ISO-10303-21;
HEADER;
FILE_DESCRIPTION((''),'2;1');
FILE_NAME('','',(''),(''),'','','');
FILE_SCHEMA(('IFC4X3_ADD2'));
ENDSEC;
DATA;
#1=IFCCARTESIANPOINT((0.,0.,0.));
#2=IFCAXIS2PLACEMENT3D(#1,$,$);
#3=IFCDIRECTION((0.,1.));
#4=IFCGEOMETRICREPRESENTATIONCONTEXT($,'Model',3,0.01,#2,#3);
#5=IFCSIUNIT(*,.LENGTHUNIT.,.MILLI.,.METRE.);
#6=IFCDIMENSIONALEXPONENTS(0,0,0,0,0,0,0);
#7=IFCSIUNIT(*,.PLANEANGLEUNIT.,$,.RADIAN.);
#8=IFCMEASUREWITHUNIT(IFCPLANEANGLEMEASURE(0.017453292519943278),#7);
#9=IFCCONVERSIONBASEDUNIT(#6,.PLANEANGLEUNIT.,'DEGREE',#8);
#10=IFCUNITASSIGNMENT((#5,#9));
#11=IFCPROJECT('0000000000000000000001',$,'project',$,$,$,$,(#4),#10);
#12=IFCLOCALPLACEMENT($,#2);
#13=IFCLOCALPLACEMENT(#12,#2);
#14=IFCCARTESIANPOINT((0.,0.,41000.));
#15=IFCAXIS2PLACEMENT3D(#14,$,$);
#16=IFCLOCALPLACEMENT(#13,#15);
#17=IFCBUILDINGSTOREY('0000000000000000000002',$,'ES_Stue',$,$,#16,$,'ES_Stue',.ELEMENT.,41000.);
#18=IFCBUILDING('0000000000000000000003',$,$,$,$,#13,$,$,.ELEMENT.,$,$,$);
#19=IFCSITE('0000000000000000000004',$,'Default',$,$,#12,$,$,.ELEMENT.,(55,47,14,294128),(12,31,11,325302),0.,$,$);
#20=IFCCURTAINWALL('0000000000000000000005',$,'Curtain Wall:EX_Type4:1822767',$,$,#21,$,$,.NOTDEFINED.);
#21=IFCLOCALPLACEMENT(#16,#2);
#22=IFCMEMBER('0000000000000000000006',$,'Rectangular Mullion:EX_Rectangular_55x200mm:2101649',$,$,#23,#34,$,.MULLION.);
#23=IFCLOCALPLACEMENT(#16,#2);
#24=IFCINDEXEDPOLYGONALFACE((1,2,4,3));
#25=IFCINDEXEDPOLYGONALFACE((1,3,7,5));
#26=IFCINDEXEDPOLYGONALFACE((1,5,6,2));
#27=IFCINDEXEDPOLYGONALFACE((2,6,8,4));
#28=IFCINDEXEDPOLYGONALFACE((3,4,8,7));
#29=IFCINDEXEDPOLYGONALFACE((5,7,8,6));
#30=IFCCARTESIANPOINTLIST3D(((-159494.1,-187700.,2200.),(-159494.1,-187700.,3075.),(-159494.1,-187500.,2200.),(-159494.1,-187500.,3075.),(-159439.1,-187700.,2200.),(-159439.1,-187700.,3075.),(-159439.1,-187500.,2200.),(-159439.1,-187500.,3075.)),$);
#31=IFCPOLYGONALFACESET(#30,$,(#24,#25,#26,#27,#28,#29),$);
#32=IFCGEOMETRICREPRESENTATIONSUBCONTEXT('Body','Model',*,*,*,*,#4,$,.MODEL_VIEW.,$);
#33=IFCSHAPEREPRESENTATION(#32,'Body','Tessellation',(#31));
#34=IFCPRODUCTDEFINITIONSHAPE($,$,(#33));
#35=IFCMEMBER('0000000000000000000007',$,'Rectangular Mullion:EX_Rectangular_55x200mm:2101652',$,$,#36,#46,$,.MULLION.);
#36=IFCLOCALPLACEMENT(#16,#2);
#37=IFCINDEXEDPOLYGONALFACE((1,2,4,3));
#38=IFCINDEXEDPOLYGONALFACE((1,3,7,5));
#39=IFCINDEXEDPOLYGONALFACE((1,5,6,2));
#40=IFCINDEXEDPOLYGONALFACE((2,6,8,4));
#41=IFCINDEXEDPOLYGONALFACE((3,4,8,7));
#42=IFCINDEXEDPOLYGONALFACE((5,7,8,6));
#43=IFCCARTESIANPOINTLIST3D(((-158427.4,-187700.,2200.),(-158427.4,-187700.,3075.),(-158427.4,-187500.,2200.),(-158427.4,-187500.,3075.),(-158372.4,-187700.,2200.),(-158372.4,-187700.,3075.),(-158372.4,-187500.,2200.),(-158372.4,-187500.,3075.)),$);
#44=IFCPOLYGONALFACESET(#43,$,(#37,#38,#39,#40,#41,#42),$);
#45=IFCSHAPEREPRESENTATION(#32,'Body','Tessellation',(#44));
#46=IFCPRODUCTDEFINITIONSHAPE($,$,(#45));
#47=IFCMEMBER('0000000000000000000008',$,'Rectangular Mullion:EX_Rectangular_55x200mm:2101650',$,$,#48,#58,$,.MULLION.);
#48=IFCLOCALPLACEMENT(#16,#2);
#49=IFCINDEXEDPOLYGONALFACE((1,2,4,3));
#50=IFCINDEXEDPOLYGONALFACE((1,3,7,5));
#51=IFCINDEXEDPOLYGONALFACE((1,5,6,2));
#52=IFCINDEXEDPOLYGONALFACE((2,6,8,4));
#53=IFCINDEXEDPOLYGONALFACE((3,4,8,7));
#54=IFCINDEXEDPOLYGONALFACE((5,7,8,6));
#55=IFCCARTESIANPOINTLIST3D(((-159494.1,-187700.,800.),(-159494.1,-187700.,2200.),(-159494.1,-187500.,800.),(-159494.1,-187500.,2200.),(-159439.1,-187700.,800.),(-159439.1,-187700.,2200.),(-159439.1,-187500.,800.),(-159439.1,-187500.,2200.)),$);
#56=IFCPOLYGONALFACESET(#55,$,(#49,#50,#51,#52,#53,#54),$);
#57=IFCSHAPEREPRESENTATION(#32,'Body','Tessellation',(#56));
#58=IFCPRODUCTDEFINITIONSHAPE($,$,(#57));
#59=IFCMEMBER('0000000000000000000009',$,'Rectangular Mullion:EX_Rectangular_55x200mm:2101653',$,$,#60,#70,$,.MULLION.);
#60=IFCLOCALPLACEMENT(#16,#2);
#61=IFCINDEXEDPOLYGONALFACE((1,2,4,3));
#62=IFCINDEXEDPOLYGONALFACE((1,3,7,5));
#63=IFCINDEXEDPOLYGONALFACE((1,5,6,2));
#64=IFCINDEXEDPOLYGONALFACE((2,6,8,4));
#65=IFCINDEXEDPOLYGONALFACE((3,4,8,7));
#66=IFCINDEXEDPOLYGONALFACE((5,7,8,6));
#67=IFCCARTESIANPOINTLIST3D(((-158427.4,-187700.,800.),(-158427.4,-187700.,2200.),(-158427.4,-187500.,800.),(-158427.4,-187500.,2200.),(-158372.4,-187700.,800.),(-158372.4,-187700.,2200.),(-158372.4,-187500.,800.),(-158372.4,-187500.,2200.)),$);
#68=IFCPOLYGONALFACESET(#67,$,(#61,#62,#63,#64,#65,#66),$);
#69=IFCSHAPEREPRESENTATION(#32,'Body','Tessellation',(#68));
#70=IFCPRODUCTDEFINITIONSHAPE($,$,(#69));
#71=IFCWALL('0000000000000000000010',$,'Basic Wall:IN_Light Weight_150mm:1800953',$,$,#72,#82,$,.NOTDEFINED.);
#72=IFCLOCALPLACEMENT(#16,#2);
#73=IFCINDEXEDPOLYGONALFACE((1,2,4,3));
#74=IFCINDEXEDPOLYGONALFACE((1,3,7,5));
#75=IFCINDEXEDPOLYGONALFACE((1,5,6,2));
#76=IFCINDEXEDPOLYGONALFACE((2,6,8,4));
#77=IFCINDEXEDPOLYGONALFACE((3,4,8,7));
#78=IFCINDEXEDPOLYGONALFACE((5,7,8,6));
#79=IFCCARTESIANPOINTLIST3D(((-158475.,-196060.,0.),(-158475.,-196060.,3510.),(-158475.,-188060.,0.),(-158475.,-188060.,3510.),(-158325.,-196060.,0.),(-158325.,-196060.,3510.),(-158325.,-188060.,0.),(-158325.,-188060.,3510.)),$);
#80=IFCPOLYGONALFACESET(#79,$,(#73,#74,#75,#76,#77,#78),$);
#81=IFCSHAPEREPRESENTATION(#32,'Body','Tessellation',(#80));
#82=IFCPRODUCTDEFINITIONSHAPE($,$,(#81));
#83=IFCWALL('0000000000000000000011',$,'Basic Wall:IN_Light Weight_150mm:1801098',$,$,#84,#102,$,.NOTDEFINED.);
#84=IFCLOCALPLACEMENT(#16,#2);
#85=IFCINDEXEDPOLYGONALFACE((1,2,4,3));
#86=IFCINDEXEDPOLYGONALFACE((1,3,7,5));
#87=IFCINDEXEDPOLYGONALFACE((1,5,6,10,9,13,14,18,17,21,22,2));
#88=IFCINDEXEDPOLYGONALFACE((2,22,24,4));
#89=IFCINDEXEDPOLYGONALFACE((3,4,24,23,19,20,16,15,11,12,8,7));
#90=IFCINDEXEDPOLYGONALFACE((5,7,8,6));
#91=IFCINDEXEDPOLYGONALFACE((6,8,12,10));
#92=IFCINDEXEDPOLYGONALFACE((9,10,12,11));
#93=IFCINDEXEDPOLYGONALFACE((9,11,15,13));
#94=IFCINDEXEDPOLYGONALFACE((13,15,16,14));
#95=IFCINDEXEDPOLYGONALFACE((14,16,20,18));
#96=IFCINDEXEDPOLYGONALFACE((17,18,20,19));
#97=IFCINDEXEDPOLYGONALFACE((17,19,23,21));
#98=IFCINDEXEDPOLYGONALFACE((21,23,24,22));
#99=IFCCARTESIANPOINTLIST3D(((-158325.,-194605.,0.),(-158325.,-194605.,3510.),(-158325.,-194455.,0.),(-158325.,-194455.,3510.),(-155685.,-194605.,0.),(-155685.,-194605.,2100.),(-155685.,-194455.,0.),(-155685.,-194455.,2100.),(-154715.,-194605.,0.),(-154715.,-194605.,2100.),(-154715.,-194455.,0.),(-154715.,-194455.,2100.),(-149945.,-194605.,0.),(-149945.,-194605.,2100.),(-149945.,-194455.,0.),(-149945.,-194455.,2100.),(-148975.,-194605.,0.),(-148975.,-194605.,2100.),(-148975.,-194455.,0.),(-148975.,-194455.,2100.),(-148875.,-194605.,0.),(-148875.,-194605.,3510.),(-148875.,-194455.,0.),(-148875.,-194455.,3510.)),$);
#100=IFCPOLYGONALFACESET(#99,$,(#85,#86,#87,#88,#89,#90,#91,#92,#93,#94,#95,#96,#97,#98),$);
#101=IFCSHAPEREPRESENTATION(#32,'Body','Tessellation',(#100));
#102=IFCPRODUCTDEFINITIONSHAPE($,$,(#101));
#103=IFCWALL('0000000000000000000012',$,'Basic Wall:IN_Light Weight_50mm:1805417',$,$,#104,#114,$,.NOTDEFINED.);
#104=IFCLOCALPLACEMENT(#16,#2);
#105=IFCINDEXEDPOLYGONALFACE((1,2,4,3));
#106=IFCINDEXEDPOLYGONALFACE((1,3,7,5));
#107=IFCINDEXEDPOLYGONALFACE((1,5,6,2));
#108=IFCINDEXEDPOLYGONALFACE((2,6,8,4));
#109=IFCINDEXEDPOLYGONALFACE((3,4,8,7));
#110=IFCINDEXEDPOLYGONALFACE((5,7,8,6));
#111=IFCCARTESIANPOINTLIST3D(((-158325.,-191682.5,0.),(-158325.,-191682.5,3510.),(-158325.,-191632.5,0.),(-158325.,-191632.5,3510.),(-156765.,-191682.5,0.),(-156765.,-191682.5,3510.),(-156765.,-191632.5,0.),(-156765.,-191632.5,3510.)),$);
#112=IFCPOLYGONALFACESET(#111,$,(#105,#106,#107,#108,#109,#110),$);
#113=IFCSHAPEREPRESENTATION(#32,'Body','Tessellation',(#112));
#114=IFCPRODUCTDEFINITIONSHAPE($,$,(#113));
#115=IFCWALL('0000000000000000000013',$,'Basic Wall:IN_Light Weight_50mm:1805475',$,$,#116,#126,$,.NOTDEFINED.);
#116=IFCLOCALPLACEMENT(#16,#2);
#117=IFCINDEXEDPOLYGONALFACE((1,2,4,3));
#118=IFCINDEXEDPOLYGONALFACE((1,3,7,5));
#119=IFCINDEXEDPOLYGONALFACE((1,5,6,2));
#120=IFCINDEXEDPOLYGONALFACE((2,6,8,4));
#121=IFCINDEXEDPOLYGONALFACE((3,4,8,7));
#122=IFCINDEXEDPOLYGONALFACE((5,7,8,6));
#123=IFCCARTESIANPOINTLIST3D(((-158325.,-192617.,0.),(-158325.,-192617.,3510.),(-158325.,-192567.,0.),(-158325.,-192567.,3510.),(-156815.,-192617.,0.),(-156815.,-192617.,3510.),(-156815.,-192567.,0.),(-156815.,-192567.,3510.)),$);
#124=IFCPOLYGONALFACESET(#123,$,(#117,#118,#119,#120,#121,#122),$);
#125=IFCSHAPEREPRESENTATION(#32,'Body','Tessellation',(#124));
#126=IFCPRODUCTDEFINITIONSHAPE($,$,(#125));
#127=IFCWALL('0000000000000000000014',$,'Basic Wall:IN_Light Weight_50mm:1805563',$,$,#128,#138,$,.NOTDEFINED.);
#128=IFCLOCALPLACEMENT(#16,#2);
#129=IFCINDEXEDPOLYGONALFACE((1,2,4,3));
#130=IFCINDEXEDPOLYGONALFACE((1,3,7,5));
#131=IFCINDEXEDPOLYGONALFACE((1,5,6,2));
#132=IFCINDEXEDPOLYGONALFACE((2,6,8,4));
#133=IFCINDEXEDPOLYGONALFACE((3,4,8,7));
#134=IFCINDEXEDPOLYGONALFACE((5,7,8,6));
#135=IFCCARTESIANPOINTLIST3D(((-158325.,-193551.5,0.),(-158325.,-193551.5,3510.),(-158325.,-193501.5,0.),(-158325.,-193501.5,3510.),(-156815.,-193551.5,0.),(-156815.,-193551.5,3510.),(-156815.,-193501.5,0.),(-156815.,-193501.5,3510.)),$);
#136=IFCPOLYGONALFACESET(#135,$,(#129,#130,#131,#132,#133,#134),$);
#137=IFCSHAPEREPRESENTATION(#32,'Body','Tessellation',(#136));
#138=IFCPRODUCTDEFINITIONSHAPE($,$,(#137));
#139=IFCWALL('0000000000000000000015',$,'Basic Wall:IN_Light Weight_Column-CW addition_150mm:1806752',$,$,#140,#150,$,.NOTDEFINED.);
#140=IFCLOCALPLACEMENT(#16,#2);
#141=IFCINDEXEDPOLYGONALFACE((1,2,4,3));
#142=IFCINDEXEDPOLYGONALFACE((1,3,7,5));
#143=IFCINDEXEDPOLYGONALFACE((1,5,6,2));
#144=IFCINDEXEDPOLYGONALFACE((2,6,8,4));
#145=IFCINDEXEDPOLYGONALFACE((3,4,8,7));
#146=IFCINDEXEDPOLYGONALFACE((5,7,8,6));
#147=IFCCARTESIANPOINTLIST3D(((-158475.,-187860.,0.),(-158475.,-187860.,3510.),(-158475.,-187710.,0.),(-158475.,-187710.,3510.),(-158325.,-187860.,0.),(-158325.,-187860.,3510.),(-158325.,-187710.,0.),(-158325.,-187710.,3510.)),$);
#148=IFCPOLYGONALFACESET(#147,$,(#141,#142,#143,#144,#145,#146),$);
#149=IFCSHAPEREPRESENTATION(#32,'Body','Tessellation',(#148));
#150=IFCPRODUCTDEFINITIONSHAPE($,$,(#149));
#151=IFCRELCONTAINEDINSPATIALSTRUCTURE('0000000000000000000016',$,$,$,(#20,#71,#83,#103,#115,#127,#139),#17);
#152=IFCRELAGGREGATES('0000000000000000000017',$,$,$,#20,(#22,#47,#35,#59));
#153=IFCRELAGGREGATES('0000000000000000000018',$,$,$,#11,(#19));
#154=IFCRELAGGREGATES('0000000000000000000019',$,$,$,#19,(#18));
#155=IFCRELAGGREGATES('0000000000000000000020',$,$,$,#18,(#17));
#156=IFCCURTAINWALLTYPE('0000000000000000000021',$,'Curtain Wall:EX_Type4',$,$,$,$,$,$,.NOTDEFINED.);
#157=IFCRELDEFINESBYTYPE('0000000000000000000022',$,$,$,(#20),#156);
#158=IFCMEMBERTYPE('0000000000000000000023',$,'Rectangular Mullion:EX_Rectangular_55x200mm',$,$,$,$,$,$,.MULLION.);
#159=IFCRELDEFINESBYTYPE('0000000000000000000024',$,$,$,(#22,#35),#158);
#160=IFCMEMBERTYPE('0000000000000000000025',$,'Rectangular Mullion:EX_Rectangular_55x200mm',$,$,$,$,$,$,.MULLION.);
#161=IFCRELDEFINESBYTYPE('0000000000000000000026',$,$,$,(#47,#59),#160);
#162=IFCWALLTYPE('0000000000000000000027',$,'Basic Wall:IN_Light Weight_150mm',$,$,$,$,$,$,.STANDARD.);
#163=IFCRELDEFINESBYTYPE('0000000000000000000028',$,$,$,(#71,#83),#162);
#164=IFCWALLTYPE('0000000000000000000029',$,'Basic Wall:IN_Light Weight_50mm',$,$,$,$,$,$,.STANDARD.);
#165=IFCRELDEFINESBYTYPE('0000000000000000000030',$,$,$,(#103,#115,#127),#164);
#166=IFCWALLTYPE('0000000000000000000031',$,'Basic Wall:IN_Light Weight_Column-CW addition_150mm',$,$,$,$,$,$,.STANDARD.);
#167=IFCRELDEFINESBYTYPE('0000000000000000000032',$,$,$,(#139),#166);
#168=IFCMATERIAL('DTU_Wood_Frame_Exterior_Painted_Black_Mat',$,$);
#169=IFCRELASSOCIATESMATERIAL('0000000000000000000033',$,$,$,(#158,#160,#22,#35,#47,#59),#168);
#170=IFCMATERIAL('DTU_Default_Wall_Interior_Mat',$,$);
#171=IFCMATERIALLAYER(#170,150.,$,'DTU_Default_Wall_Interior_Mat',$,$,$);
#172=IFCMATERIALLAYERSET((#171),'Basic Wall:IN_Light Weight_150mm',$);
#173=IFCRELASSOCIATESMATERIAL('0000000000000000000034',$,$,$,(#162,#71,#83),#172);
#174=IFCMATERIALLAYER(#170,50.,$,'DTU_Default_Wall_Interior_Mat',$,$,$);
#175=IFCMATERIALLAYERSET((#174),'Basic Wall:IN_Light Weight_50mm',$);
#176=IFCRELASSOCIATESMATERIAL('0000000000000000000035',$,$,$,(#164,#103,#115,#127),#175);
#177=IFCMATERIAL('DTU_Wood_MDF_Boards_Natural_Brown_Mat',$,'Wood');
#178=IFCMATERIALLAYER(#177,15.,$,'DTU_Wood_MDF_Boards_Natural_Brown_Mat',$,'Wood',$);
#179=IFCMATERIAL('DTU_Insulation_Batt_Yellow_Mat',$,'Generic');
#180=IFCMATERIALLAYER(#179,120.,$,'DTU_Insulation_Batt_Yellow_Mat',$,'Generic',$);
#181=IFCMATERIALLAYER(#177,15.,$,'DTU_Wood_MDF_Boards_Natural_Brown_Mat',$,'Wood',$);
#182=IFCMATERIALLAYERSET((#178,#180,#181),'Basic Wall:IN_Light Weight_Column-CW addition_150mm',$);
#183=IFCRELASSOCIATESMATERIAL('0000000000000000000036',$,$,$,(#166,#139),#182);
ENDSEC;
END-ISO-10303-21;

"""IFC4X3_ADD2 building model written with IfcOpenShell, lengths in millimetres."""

from ifc_helpers import new_model, entity, si_unit, converted_unit, direction, frame, frame_2d, origin, origin_2d_with_axis, place, context, subcontext, project, spatial, rectangle, extrude, source, transform, mapped, material, layer, layer_set, material_profile, profile_set, profile_usage, type_object, type_shapes, element, aggregate, save


model = new_model("IFC4X3_ADD2")

# Units and contexts
model_context = context("Model", 3, precision=0.01, world=origin(), true_north=direction((0.0, 1.0)))
body_context = subcontext(model_context, "Body", "Model", "MODEL_VIEW")
ifc_project = project(units=[si_unit("LENGTHUNIT", "METRE", prefix="MILLI"), converted_unit("PLANEANGLEUNIT", "DEGREE", entity("IfcPlaneAngleMeasure", 0.017453292519943278), si_unit("PLANEANGLEUNIT", "RADIAN"), dimensions=[0, 0, 0, 0, 0, 0, 0])], contexts=[model_context])

# Site, building, storey
site_placement = place(None, origin())
site = spatial("IfcSite", under=ifc_project, at=site_placement, Name="Default", CompositionType="ELEMENT", RefLatitude=(55, 47, 14, 294128), RefLongitude=(12, 31, 11, 325302), RefElevation=0.0)
building_placement = place(site_placement, origin())
building = spatial("IfcBuilding", under=site, at=building_placement, CompositionType="ELEMENT")
storey_placement = place(building_placement, frame((0.0, 0.0, 41000.0)))
storey = spatial("IfcBuildingStorey", under=building, at=storey_placement, Name="ES_Stue", LongName="ES_Stue", CompositionType="ELEMENT", Elevation=41000.0)

# Curtain wall, members
curtain_wall_type = type_object("IfcCurtainWallType", Name="Curtain Wall:EX_Type4", PredefinedType="NOTDEFINED")
curtain_wall_placement = place(storey_placement, frame((0.0, 0.0, -41000.0)))
curtain_wall = element("IfcCurtainWall", 1, at=curtain_wall_placement, inside=storey, type_object=curtain_wall_type, Name="Curtain Wall:EX_Type4:1822767", PredefinedType="NOTDEFINED")
ifc_material_1 = material(Name="DTU_Wood_Frame_Exterior_Painted_Black_Mat")
ifc_material_profile = material_profile(ifc_material_1, rectangle(XDim=55.0, YDim=200.0, at=origin_2d_with_axis()), Name="EX_Rectangular_55x200mm")
ifc_profile_set = profile_set([ifc_material_profile], Name="EX_Rectangular_55x200mm")
ifc_profile_usage = profile_usage(ifc_profile_set)
member_type_1 = type_object("IfcMemberType", Name="Rectangular Mullion:EX_Rectangular_55x200mm", PredefinedType="MULLION", material=ifc_profile_set)
shared_shape_1 = source(origin(), body_context, "Body", "SweptSolid", [
    extrude(rectangle(XDim=55.0, YDim=200.0, at=origin_2d_with_axis()), frame((0.0, -100.0, -875.0), z_axis=(0.0, 0.0, 1.0), x_axis=(-1.0, 0.0, 0.0)), (0.0, 0.0, 1.0), 875.0),
])
type_shapes(member_type_1, [shared_shape_1])
member_1_placement = place(curtain_wall_placement, frame((-159466.6, -187500.0, 43200.0), z_axis=(0.0, 0.0, -1.0), x_axis=(-1.0, 0.0, 0.0)))
member_1 = element("IfcMember", 2, at=member_1_placement, type_object=member_type_1, material=ifc_profile_usage, Name="Rectangular Mullion:EX_Rectangular_55x200mm:2101649", PredefinedType="MULLION", context=body_context, shape_type="MappedRepresentation", body=[
    mapped(shared_shape_1, transform((0.0, 0.0, 0.0), scale=1.0)),
])
member_2_placement = place(curtain_wall_placement, frame((-158399.9, -187500.0, 43200.0), z_axis=(0.0, 0.0, -1.0), x_axis=(-1.0, 0.0, 0.0)))
member_2 = element("IfcMember", 3, at=member_2_placement, type_object=member_type_1, material=ifc_profile_usage, Name="Rectangular Mullion:EX_Rectangular_55x200mm:2101652", PredefinedType="MULLION", context=body_context, shape_type="MappedRepresentation", body=[
    mapped(shared_shape_1, transform((0.0, 0.0, 0.0), scale=1.0)),
])
member_type_2 = type_object("IfcMemberType", Name="Rectangular Mullion:EX_Rectangular_55x200mm", PredefinedType="MULLION", material=ifc_profile_set)
shared_shape_2 = source(origin(), body_context, "Body", "SweptSolid", [
    extrude(rectangle(XDim=55.0, YDim=200.0, at=origin_2d_with_axis()), frame((0.0, -100.0, -1400.0), z_axis=(0.0, 0.0, 1.0), x_axis=(-1.0, 0.0, 0.0)), (0.0, 0.0, 1.0), 1400.0),
])
type_shapes(member_type_2, [shared_shape_2])
member_3_placement = place(curtain_wall_placement, frame((-159466.6, -187500.0, 41800.0), z_axis=(0.0, 0.0, -1.0), x_axis=(-1.0, 0.0, 0.0)))
member_3 = element("IfcMember", 4, at=member_3_placement, type_object=member_type_2, material=ifc_profile_usage, Name="Rectangular Mullion:EX_Rectangular_55x200mm:2101650", PredefinedType="MULLION", context=body_context, shape_type="MappedRepresentation", body=[
    mapped(shared_shape_2, transform((0.0, 0.0, 0.0), scale=1.0)),
])
member_4_placement = place(curtain_wall_placement, frame((-158399.9, -187500.0, 41800.0), z_axis=(0.0, 0.0, -1.0), x_axis=(-1.0, 0.0, 0.0)))
member_4 = element("IfcMember", 5, at=member_4_placement, type_object=member_type_2, material=ifc_profile_usage, Name="Rectangular Mullion:EX_Rectangular_55x200mm:2101653", PredefinedType="MULLION", context=body_context, shape_type="MappedRepresentation", body=[
    mapped(shared_shape_2, transform((0.0, 0.0, 0.0), scale=1.0)),
])

# Wall
ifc_material_2 = material(Name="DTU_Default_Wall_Interior_Mat")
ifc_layer_1 = layer(ifc_material_2, 150.0, Name="DTU_Default_Wall_Interior_Mat")
ifc_layer_set_1 = layer_set([ifc_layer_1], Name="Basic Wall:IN_Light Weight_150mm")
wall_type_1 = type_object("IfcWallType", Name="Basic Wall:IN_Light Weight_150mm", PredefinedType="STANDARD", material=ifc_layer_set_1)
wall_1_placement = place(storey_placement, frame((-158400.0, -188060.0, 0.0), z_axis=(0.0, 0.0, 1.0), x_axis=(0.0, -1.0, 0.0)))
element("IfcWall", 6, at=wall_1_placement, inside=storey, type_object=wall_type_1, material=ifc_layer_set_1, Name="Basic Wall:IN_Light Weight_150mm:1800953", PredefinedType="NOTDEFINED", context=body_context, shape_type="SweptSolid", body=[
    extrude(rectangle(XDim=8000.0, YDim=150.0, at=frame_2d((4000.0, 0.0), x_axis=(-1.0, 0.0))), origin(), (0.0, 0.0, 1.0), 3510.0),
])

# Wall, openings
wall_2_placement = place(storey_placement, frame((-158325.0, -194530.0, 0.0)))
wall_2 = element("IfcWall", 7, at=wall_2_placement, inside=storey, type_object=wall_type_1, material=ifc_layer_set_1, Name="Basic Wall:IN_Light Weight_150mm:1801098", PredefinedType="NOTDEFINED", context=body_context, shape_type="SweptSolid", body=[
    extrude(rectangle(XDim=9450.0, YDim=150.0, at=frame_2d((4725.0, 0.0), x_axis=(1.0, 0.0))), origin(), (0.0, 0.0, 1.0), 3510.0),
])
opening_1_placement = place(wall_2_placement, frame((8380.0, -75.0, 0.0)))
element("IfcOpeningElement", 8, at=opening_1_placement, cuts=wall_2, PredefinedType="OPENING", context=body_context, shape_type="SweptSolid", body=[
    extrude(rectangle(XDim=2100.0, YDim=970.0, at=frame_2d((1050.0, 485.0), x_axis=(1.0, 0.0))), frame((0.0, 0.0, 0.0), z_axis=(0.0, 1.0, 0.0), x_axis=(0.0, 0.0, 1.0)), (0.0, 0.0, 1.0), 150.0),
])
opening_2_placement = place(wall_2_placement, frame((2640.0, -75.0, 0.0)))
element("IfcOpeningElement", 9, at=opening_2_placement, cuts=wall_2, PredefinedType="OPENING", context=body_context, shape_type="SweptSolid", body=[
    extrude(rectangle(XDim=2100.0, YDim=970.0, at=frame_2d((1050.0, 485.0), x_axis=(1.0, 0.0))), frame((0.0, 0.0, 0.0), z_axis=(0.0, 1.0, 0.0), x_axis=(0.0, 0.0, 1.0)), (0.0, 0.0, 1.0), 150.0),
])

# Walls
ifc_layer_2 = layer(ifc_material_2, 50.0, Name="DTU_Default_Wall_Interior_Mat")
ifc_layer_set_2 = layer_set([ifc_layer_2], Name="Basic Wall:IN_Light Weight_50mm")
wall_type_2 = type_object("IfcWallType", Name="Basic Wall:IN_Light Weight_50mm", PredefinedType="STANDARD", material=ifc_layer_set_2)
wall_3_placement = place(storey_placement, frame((-158325.0, -191657.5, 0.0)))
element("IfcWall", 10, at=wall_3_placement, inside=storey, type_object=wall_type_2, material=ifc_layer_set_2, Name="Basic Wall:IN_Light Weight_50mm:1805417", PredefinedType="NOTDEFINED", context=body_context, shape_type="SweptSolid", body=[
    extrude(rectangle(XDim=1560.0, YDim=50.0, at=frame_2d((780.0, 0.0), x_axis=(-1.0, 0.0))), origin(), (0.0, 0.0, 1.0), 3510.0),
])
for number, where, name in (
    (11, (-158325.0, -192592.0, 0.0), "Basic Wall:IN_Light Weight_50mm:1805475"),
    (12, (-158325.0, -193526.5, 0.0), "Basic Wall:IN_Light Weight_50mm:1805563"),
):
    element("IfcWall", number, at=place(storey_placement, frame(where)), inside=storey, type_object=wall_type_2, material=ifc_layer_set_2, Name=name, PredefinedType="NOTDEFINED", context=body_context, shape_type="SweptSolid", body=[
        extrude(rectangle(XDim=1510.0, YDim=50.0, at=frame_2d((755.0, 0.0), x_axis=(-1.0, 0.0))), origin(), (0.0, 0.0, 1.0), 3510.0),
    ])
ifc_material_3 = material(Name="DTU_Wood_MDF_Boards_Natural_Brown_Mat", Category="Wood")
ifc_layer_3 = layer(ifc_material_3, 15.0, Name="DTU_Wood_MDF_Boards_Natural_Brown_Mat", Category="Wood")
ifc_material_4 = material(Name="DTU_Insulation_Batt_Yellow_Mat", Category="Generic")
ifc_layer_4 = layer(ifc_material_4, 120.0, Name="DTU_Insulation_Batt_Yellow_Mat", Category="Generic")
ifc_layer_5 = layer(ifc_material_3, 15.0, Name="DTU_Wood_MDF_Boards_Natural_Brown_Mat", Category="Wood")
ifc_layer_set_3 = layer_set([ifc_layer_3, ifc_layer_4, ifc_layer_5], Name="Basic Wall:IN_Light Weight_Column-CW addition_150mm")
wall_type_3 = type_object("IfcWallType", Name="Basic Wall:IN_Light Weight_Column-CW addition_150mm", PredefinedType="STANDARD", material=ifc_layer_set_3)
wall_4_placement = place(storey_placement, frame((-158400.0, -187710.0, 0.0), z_axis=(0.0, 0.0, 1.0), x_axis=(0.0, -1.0, 0.0)))
element("IfcWall", 13, at=wall_4_placement, inside=storey, type_object=wall_type_3, material=ifc_layer_set_3, Name="Basic Wall:IN_Light Weight_Column-CW addition_150mm:1806752", PredefinedType="NOTDEFINED", context=body_context, shape_type="SweptSolid", body=[
    extrude(rectangle(XDim=150.0, YDim=150.0, at=frame_2d((75.0, 0.0), x_axis=(-1.0, 0.0))), origin(), (0.0, 0.0, 1.0), 3510.0),
])

aggregate(curtain_wall, [member_1, member_3, member_2, member_4])

save(model, "model.ifc")
